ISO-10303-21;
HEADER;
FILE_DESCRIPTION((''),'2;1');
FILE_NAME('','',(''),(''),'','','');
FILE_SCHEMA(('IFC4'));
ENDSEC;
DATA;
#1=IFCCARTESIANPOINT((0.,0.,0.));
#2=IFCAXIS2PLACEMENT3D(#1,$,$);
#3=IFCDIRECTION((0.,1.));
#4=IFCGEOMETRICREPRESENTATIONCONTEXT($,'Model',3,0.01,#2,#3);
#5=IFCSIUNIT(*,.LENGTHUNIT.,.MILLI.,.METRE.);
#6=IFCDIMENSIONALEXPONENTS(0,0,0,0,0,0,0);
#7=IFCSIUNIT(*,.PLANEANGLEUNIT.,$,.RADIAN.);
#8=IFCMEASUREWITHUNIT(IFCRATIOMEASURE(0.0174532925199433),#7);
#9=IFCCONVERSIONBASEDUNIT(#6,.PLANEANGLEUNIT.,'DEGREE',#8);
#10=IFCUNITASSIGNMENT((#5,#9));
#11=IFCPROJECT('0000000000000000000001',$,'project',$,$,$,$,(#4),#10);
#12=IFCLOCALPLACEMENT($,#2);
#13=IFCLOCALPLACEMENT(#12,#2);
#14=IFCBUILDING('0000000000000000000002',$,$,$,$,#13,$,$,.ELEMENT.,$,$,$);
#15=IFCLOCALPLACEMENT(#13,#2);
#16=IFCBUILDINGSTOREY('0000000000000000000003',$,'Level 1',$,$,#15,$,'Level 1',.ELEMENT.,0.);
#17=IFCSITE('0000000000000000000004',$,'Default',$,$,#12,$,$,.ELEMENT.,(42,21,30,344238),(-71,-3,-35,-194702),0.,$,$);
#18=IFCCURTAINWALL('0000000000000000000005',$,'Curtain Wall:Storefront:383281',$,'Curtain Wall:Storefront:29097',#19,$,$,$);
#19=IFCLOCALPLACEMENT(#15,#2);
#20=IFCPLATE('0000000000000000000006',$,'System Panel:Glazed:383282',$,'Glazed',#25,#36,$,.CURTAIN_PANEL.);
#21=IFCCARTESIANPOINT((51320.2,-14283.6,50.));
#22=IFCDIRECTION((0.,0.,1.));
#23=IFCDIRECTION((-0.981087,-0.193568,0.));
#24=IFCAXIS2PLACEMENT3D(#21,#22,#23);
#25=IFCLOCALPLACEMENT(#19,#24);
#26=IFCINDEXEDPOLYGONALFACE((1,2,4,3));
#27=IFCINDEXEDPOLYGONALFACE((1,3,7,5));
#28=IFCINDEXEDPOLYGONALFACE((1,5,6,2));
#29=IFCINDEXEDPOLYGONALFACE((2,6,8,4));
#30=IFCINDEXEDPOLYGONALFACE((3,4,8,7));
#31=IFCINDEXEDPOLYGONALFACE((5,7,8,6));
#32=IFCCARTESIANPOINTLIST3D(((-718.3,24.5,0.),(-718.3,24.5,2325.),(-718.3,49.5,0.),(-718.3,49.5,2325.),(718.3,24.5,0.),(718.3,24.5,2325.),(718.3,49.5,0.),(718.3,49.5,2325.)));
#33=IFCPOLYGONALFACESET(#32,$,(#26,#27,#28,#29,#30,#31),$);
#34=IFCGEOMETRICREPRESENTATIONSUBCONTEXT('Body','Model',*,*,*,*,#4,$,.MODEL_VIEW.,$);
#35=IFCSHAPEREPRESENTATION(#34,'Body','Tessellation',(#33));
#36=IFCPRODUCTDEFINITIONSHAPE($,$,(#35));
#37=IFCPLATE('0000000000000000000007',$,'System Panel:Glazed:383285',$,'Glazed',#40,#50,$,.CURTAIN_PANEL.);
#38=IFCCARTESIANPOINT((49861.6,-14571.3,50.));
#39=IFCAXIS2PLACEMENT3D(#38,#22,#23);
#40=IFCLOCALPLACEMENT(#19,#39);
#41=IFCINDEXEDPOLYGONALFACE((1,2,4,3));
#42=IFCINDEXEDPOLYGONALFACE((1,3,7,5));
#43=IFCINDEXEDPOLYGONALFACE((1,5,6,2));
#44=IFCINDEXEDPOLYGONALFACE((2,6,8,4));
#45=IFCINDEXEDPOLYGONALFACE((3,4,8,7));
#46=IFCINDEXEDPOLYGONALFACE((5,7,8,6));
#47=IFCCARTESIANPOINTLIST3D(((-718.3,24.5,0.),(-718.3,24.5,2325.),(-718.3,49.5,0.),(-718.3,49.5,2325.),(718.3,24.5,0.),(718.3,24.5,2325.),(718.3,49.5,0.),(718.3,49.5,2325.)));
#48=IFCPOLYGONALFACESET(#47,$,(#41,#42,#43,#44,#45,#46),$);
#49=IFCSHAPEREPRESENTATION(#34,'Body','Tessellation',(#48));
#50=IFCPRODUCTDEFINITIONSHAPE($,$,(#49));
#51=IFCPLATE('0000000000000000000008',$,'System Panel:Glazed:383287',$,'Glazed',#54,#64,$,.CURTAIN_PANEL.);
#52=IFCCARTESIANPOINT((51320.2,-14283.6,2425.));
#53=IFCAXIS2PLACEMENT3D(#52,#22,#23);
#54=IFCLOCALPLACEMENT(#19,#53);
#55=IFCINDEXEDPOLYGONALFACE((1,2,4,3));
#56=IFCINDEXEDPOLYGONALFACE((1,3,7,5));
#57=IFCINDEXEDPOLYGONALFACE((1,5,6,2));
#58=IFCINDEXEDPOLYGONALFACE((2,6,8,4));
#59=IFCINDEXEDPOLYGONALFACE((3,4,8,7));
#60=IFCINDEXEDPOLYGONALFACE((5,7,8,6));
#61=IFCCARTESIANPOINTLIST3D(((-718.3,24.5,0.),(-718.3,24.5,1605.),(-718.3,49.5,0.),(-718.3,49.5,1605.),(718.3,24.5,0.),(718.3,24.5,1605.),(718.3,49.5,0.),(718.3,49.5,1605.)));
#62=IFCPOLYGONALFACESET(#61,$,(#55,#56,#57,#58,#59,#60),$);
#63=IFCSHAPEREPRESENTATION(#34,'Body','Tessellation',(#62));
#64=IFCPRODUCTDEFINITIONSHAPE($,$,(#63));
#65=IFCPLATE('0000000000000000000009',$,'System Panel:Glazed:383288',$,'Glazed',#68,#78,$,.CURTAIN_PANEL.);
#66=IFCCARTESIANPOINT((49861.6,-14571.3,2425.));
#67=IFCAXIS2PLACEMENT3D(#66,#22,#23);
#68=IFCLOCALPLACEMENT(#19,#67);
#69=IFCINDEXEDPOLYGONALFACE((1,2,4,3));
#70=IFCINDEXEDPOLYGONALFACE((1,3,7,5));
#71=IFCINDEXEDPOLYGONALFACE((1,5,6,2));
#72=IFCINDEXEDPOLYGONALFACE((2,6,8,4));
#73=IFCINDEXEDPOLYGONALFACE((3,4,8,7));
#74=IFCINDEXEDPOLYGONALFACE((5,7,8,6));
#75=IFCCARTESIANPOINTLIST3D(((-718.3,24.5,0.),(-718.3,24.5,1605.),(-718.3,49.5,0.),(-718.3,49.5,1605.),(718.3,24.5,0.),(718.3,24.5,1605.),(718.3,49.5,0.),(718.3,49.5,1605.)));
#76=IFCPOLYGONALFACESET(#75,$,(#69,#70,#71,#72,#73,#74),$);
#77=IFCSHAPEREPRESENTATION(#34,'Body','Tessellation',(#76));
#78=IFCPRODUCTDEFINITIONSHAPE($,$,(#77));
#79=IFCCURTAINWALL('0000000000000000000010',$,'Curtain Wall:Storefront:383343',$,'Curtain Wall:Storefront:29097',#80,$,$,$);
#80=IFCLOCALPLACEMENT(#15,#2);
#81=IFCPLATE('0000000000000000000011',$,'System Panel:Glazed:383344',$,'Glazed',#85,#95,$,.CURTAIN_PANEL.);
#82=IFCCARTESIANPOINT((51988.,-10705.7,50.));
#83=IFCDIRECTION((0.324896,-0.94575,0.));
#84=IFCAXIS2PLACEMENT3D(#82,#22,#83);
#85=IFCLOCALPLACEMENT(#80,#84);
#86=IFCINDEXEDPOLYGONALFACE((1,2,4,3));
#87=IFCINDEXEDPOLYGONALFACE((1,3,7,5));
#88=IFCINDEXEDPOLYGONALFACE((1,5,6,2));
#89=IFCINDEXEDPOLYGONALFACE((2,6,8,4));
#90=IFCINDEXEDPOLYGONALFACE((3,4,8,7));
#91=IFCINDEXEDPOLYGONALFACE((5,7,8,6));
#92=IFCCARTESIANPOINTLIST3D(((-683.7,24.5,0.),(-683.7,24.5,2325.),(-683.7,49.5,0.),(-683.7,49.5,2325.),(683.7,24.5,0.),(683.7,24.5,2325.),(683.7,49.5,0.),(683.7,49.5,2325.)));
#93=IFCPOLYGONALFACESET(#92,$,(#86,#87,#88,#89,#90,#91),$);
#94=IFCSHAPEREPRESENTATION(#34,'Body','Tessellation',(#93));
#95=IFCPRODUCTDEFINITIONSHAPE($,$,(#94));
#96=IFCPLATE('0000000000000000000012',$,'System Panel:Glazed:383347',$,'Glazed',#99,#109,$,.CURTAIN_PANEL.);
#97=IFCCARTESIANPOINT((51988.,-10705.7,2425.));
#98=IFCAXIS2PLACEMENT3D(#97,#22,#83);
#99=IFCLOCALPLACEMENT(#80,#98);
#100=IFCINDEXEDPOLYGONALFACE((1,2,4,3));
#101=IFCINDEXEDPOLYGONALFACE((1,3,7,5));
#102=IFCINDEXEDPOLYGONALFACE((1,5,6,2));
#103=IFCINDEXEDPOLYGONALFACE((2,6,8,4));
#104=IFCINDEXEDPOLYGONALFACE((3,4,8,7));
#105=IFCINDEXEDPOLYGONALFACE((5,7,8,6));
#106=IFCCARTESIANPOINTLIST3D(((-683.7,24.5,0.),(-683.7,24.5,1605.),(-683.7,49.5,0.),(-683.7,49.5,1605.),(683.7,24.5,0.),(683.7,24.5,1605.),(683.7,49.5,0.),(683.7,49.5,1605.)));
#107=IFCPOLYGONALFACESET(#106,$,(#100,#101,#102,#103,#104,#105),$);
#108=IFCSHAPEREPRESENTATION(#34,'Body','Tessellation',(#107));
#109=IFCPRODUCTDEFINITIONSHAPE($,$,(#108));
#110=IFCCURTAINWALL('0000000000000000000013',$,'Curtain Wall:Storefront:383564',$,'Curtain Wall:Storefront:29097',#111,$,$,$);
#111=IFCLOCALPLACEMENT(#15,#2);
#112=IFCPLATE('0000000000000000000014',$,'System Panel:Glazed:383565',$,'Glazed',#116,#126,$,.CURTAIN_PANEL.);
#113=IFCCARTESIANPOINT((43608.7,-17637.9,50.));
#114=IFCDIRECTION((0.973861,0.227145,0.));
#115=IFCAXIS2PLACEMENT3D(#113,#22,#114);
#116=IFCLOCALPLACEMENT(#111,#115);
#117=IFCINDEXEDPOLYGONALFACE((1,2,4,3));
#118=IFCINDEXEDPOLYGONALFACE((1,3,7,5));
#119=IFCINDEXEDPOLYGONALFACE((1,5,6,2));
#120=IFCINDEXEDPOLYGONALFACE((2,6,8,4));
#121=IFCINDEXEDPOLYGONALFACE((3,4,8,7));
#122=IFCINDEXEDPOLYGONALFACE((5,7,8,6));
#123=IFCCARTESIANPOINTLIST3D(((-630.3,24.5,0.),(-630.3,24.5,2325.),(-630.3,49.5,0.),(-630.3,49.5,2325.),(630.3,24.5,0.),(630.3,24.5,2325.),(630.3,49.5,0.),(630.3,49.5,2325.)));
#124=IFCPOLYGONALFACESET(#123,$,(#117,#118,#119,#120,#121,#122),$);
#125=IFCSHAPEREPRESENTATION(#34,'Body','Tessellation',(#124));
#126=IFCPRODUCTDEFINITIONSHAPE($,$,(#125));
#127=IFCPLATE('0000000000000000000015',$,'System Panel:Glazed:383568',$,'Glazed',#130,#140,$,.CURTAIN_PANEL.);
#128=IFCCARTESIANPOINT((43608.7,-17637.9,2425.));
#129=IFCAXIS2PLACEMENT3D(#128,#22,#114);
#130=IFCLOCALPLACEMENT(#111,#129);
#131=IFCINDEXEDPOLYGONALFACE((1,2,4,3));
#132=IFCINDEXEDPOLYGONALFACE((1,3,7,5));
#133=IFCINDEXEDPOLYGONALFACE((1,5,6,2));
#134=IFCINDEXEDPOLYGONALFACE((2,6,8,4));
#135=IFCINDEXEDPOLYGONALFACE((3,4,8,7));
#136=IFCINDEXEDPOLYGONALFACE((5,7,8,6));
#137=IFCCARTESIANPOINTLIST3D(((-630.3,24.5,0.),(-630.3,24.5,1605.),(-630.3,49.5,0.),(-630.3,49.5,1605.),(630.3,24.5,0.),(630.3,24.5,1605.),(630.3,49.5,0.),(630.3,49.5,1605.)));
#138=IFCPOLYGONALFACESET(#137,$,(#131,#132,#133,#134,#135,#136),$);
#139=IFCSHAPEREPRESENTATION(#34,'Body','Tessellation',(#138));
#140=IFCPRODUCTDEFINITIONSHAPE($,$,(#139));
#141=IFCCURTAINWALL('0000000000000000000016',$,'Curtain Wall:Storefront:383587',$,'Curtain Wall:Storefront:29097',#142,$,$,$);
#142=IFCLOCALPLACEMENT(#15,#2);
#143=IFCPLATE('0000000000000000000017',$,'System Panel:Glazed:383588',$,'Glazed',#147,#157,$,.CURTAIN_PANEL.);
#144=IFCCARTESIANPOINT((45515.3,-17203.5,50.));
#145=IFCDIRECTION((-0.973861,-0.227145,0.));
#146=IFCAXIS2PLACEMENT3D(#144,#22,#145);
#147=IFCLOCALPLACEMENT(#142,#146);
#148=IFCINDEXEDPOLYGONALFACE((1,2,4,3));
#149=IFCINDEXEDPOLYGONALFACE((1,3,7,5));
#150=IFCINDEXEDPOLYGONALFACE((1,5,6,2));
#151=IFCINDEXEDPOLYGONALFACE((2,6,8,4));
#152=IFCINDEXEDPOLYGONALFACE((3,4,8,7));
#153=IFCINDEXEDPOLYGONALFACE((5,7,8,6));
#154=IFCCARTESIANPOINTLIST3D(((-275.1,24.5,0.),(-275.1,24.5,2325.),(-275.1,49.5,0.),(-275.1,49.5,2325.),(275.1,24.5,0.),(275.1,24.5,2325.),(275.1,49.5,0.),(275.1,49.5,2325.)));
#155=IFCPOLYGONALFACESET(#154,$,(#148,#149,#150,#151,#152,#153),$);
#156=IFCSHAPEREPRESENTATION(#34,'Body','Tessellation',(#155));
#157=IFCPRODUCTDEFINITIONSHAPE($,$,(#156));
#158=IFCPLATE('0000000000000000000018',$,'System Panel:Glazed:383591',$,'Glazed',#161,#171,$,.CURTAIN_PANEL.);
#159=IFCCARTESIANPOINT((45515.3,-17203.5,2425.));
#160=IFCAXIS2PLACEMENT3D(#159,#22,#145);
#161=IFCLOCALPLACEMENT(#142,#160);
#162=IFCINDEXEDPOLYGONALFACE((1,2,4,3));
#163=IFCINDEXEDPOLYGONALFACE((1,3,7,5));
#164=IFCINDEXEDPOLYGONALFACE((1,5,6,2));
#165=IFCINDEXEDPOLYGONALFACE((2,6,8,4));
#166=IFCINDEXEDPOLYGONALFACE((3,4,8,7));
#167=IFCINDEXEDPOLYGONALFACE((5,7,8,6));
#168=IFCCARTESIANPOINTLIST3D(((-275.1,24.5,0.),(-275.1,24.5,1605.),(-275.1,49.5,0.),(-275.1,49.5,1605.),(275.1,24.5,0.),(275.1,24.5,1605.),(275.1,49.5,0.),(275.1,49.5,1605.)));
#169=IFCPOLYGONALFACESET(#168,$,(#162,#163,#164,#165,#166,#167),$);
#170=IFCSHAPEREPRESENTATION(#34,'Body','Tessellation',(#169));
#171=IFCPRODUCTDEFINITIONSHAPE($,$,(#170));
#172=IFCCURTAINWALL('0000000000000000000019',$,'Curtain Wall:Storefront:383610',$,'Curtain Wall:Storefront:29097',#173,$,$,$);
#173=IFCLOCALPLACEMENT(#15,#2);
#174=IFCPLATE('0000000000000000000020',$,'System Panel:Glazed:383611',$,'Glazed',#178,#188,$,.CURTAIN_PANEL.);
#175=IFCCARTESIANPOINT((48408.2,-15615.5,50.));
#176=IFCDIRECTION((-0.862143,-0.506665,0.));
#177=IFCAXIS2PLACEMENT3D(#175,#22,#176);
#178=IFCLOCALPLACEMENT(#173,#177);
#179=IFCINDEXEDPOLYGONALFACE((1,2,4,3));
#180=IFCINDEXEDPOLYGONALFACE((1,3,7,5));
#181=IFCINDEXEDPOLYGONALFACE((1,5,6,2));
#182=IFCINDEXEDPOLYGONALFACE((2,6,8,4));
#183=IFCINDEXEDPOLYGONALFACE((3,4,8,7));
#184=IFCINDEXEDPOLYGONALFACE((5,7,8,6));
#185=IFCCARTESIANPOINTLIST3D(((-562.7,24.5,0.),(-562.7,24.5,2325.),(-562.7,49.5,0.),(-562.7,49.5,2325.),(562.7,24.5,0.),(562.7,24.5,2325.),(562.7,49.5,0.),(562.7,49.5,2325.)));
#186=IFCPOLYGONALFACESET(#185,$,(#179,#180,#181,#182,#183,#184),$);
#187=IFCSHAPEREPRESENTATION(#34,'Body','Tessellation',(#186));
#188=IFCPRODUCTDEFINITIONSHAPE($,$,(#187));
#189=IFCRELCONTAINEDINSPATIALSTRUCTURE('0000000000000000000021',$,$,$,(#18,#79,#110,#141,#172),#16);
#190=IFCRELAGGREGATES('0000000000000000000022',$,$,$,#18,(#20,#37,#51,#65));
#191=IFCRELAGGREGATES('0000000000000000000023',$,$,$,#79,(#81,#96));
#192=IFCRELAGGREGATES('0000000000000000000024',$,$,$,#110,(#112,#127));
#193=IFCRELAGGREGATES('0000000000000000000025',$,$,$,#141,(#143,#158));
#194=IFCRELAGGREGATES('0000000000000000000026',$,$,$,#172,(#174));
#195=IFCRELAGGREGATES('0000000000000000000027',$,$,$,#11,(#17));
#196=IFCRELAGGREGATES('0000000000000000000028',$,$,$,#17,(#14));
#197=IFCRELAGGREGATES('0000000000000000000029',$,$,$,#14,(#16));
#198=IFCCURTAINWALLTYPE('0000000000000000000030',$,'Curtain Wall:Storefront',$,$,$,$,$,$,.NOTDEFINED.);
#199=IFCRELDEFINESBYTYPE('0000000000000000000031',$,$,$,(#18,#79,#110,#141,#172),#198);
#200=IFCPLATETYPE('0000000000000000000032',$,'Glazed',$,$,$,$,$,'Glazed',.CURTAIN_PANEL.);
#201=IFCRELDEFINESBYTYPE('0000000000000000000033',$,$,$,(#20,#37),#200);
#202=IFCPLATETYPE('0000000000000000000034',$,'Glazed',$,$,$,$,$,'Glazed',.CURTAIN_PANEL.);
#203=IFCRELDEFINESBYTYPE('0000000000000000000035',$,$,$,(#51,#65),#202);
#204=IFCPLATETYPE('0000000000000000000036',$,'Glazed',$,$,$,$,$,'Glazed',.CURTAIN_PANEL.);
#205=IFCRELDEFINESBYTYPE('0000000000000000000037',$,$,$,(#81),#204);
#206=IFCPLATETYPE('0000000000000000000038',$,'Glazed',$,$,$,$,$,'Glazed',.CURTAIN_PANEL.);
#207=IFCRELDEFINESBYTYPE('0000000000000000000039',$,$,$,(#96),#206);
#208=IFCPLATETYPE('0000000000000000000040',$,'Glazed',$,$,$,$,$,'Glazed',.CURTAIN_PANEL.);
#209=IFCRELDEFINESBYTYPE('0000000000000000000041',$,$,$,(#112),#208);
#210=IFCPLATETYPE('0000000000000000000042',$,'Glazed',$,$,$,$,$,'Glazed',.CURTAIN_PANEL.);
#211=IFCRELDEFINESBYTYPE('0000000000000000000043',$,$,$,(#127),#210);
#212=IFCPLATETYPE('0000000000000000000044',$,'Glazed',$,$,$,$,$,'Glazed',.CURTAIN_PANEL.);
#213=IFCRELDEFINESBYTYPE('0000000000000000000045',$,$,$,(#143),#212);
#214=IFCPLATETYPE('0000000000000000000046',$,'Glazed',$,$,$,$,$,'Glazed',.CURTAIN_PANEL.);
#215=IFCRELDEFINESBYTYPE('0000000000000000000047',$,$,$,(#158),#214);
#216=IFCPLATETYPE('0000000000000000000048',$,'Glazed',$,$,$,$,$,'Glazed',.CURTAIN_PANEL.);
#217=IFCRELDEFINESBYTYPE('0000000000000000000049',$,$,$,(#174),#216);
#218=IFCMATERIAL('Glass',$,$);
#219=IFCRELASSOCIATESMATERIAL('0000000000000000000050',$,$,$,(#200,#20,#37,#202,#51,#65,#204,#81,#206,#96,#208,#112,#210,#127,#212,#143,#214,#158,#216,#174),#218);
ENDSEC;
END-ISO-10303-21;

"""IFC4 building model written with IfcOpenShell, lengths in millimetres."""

from ifc_helpers import new_model, entity, si_unit, converted_unit, direction, frame, frame_2d, origin, place, context, subcontext, project, spatial, rectangle, extrude, source, transform, mapped, material, type_object, type_shapes, element, aggregate, save


model = new_model("IFC4")

# Units and contexts
model_context = context("Model", 3, precision=0.01, world=origin(), true_north=direction((0.0, 1.0)))
body_context = subcontext(model_context, "Body", "Model", "MODEL_VIEW")
ifc_project = project(units=[si_unit("LENGTHUNIT", "METRE", prefix="MILLI"), converted_unit("PLANEANGLEUNIT", "DEGREE", entity("IfcRatioMeasure", 0.0174532925199433), si_unit("PLANEANGLEUNIT", "RADIAN"), dimensions=[0, 0, 0, 0, 0, 0, 0])], contexts=[model_context])

# Site, building, storey
site_placement = place(None, origin())
site = spatial("IfcSite", under=ifc_project, at=site_placement, Name="Default", CompositionType="ELEMENT", RefLatitude=(42, 21, 30, 344238), RefLongitude=(-71, -3, -35, -194702), RefElevation=0.0)
building_placement = place(site_placement, origin())
building = spatial("IfcBuilding", under=site, at=building_placement, CompositionType="ELEMENT")
storey_placement = place(building_placement, origin())
storey = spatial("IfcBuildingStorey", under=building, at=storey_placement, Name="Level 1", LongName="Level 1", CompositionType="ELEMENT", Elevation=0.0)

# Curtain walls, plates
curtain_wall_type = type_object("IfcCurtainWallType", Name="Curtain Wall:Storefront", PredefinedType="NOTDEFINED")
curtain_wall_1_placement = place(storey_placement, origin())
curtain_wall_1 = element("IfcCurtainWall", 1, at=curtain_wall_1_placement, inside=storey, type_object=curtain_wall_type, Name="Curtain Wall:Storefront:383281", ObjectType="Curtain Wall:Storefront:29097")
ifc_material_1 = material(Name="Glass")
plate_type_1 = type_object("IfcPlateType", Name="Glazed", ElementType="Glazed", PredefinedType="CURTAIN_PANEL", material=ifc_material_1)
shared_shape_1 = source(origin(), body_context, "Body", "SweptSolid", [
    extrude(rectangle(XDim=25.0, YDim=1436.7, at=frame_2d((0.0, 0.0), x_axis=(1.0, 0.0))), frame((0.0, 37.0, 0.0), z_axis=(0.0, 0.0, 1.0), x_axis=(0.0, 1.0, 0.0)), (0.0, 0.0, 1.0), 2325.0),
])
type_shapes(plate_type_1, [shared_shape_1])
plate_1_placement = place(curtain_wall_1_placement, frame((51320.2, -14283.6, 50.0), z_axis=(0.0, 0.0, 1.0), x_axis=(-0.981087, -0.193568, 0.0)))
plate_1 = element("IfcPlate", 2, at=plate_1_placement, type_object=plate_type_1, material=ifc_material_1, Name="System Panel:Glazed:383282", ObjectType="Glazed", PredefinedType="CURTAIN_PANEL", context=body_context, shape_type="MappedRepresentation", body=[
    mapped(shared_shape_1, transform((0.0, 0.0, 0.0), scale=1.0)),
])
plate_2_placement = place(curtain_wall_1_placement, frame((49861.6, -14571.3, 50.0), z_axis=(0.0, 0.0, 1.0), x_axis=(-0.981087, -0.193568, 0.0)))
plate_2 = element("IfcPlate", 3, at=plate_2_placement, type_object=plate_type_1, material=ifc_material_1, Name="System Panel:Glazed:383285", ObjectType="Glazed", PredefinedType="CURTAIN_PANEL", context=body_context, shape_type="MappedRepresentation", body=[
    mapped(shared_shape_1, transform((0.0, 0.0, 0.0), scale=1.0)),
])
plate_type_2 = type_object("IfcPlateType", Name="Glazed", ElementType="Glazed", PredefinedType="CURTAIN_PANEL", material=ifc_material_1)
shared_shape_2 = source(origin(), body_context, "Body", "SweptSolid", [
    extrude(rectangle(XDim=25.0, YDim=1436.7, at=frame_2d((0.0, 0.0), x_axis=(1.0, 0.0))), frame((0.0, 37.0, 0.0), z_axis=(0.0, 0.0, 1.0), x_axis=(0.0, 1.0, 0.0)), (0.0, 0.0, 1.0), 1605.0),
])
type_shapes(plate_type_2, [shared_shape_2])
plate_3_placement = place(curtain_wall_1_placement, frame((51320.2, -14283.6, 2425.0), z_axis=(0.0, 0.0, 1.0), x_axis=(-0.981087, -0.193568, 0.0)))
plate_3 = element("IfcPlate", 4, at=plate_3_placement, type_object=plate_type_2, material=ifc_material_1, Name="System Panel:Glazed:383287", ObjectType="Glazed", PredefinedType="CURTAIN_PANEL", context=body_context, shape_type="MappedRepresentation", body=[
    mapped(shared_shape_2, transform((0.0, 0.0, 0.0), scale=1.0)),
])
plate_4_placement = place(curtain_wall_1_placement, frame((49861.6, -14571.3, 2425.0), z_axis=(0.0, 0.0, 1.0), x_axis=(-0.981087, -0.193568, 0.0)))
plate_4 = element("IfcPlate", 5, at=plate_4_placement, type_object=plate_type_2, material=ifc_material_1, Name="System Panel:Glazed:383288", ObjectType="Glazed", PredefinedType="CURTAIN_PANEL", context=body_context, shape_type="MappedRepresentation", body=[
    mapped(shared_shape_2, transform((0.0, 0.0, 0.0), scale=1.0)),
])
aggregate(curtain_wall_1, [plate_1, plate_2, plate_3, plate_4])
curtain_wall_2_placement = place(storey_placement, origin())
curtain_wall_2 = element("IfcCurtainWall", 6, at=curtain_wall_2_placement, inside=storey, type_object=curtain_wall_type, Name="Curtain Wall:Storefront:383343", ObjectType="Curtain Wall:Storefront:29097")
plate_type_3 = type_object("IfcPlateType", Name="Glazed", ElementType="Glazed", PredefinedType="CURTAIN_PANEL", material=ifc_material_1)
shared_shape_3 = source(origin(), body_context, "Body", "SweptSolid", [
    extrude(rectangle(XDim=25.0, YDim=1367.5, at=frame_2d((0.0, 0.0), x_axis=(1.0, 0.0))), frame((0.0, 37.0, 0.0), z_axis=(0.0, 0.0, 1.0), x_axis=(0.0, 1.0, 0.0)), (0.0, 0.0, 1.0), 2325.0),
])
type_shapes(plate_type_3, [shared_shape_3])
plate_5_placement = place(curtain_wall_2_placement, frame((51988.0, -10705.7, 50.0), z_axis=(0.0, 0.0, 1.0), x_axis=(0.324896, -0.94575, 0.0)))
plate_5 = element("IfcPlate", 7, at=plate_5_placement, type_object=plate_type_3, material=ifc_material_1, Name="System Panel:Glazed:383344", ObjectType="Glazed", PredefinedType="CURTAIN_PANEL", context=body_context, shape_type="MappedRepresentation", body=[
    mapped(shared_shape_3, transform((0.0, 0.0, 0.0), scale=1.0)),
])
plate_type_4 = type_object("IfcPlateType", Name="Glazed", ElementType="Glazed", PredefinedType="CURTAIN_PANEL", material=ifc_material_1)
shared_shape_4 = source(origin(), body_context, "Body", "SweptSolid", [
    extrude(rectangle(XDim=25.0, YDim=1367.5, at=frame_2d((0.0, 0.0), x_axis=(1.0, 0.0))), frame((0.0, 37.0, 0.0), z_axis=(0.0, 0.0, 1.0), x_axis=(0.0, 1.0, 0.0)), (0.0, 0.0, 1.0), 1605.0),
])
type_shapes(plate_type_4, [shared_shape_4])
plate_6_placement = place(curtain_wall_2_placement, frame((51988.0, -10705.7, 2425.0), z_axis=(0.0, 0.0, 1.0), x_axis=(0.324896, -0.94575, 0.0)))
plate_6 = element("IfcPlate", 8, at=plate_6_placement, type_object=plate_type_4, material=ifc_material_1, Name="System Panel:Glazed:383347", ObjectType="Glazed", PredefinedType="CURTAIN_PANEL", context=body_context, shape_type="MappedRepresentation", body=[
    mapped(shared_shape_4, transform((0.0, 0.0, 0.0), scale=1.0)),
])
aggregate(curtain_wall_2, [plate_5, plate_6])
curtain_wall_3_placement = place(storey_placement, origin())
curtain_wall_3 = element("IfcCurtainWall", 9, at=curtain_wall_3_placement, inside=storey, type_object=curtain_wall_type, Name="Curtain Wall:Storefront:383564", ObjectType="Curtain Wall:Storefront:29097")
plate_type_5 = type_object("IfcPlateType", Name="Glazed", ElementType="Glazed", PredefinedType="CURTAIN_PANEL", material=ifc_material_1)
shared_shape_5 = source(origin(), body_context, "Body", "SweptSolid", [
    extrude(rectangle(XDim=25.0, YDim=1260.7, at=frame_2d((0.0, 0.0), x_axis=(1.0, 0.0))), frame((0.0, 37.0, 0.0), z_axis=(0.0, 0.0, 1.0), x_axis=(0.0, 1.0, 0.0)), (0.0, 0.0, 1.0), 2325.0),
])
type_shapes(plate_type_5, [shared_shape_5])
plate_7_placement = place(curtain_wall_3_placement, frame((43608.7, -17637.9, 50.0), z_axis=(0.0, 0.0, 1.0), x_axis=(0.973861, 0.227145, 0.0)))
plate_7 = element("IfcPlate", 10, at=plate_7_placement, type_object=plate_type_5, material=ifc_material_1, Name="System Panel:Glazed:383565", ObjectType="Glazed", PredefinedType="CURTAIN_PANEL", context=body_context, shape_type="MappedRepresentation", body=[
    mapped(shared_shape_5, transform((0.0, 0.0, 0.0), scale=1.0)),
])
plate_type_6 = type_object("IfcPlateType", Name="Glazed", ElementType="Glazed", PredefinedType="CURTAIN_PANEL", material=ifc_material_1)
shared_shape_6 = source(origin(), body_context, "Body", "SweptSolid", [
    extrude(rectangle(XDim=25.0, YDim=1260.7, at=frame_2d((0.0, 0.0), x_axis=(1.0, 0.0))), frame((0.0, 37.0, 0.0), z_axis=(0.0, 0.0, 1.0), x_axis=(0.0, 1.0, 0.0)), (0.0, 0.0, 1.0), 1605.0),
])
type_shapes(plate_type_6, [shared_shape_6])
plate_8_placement = place(curtain_wall_3_placement, frame((43608.7, -17637.9, 2425.0), z_axis=(0.0, 0.0, 1.0), x_axis=(0.973861, 0.227145, 0.0)))
plate_8 = element("IfcPlate", 11, at=plate_8_placement, type_object=plate_type_6, material=ifc_material_1, Name="System Panel:Glazed:383568", ObjectType="Glazed", PredefinedType="CURTAIN_PANEL", context=body_context, shape_type="MappedRepresentation", body=[
    mapped(shared_shape_6, transform((0.0, 0.0, 0.0), scale=1.0)),
])
aggregate(curtain_wall_3, [plate_7, plate_8])
curtain_wall_4_placement = place(storey_placement, origin())
curtain_wall_4 = element("IfcCurtainWall", 12, at=curtain_wall_4_placement, inside=storey, type_object=curtain_wall_type, Name="Curtain Wall:Storefront:383587", ObjectType="Curtain Wall:Storefront:29097")
plate_type_7 = type_object("IfcPlateType", Name="Glazed", ElementType="Glazed", PredefinedType="CURTAIN_PANEL", material=ifc_material_1)
shared_shape_7 = source(origin(), body_context, "Body", "SweptSolid", [
    extrude(rectangle(XDim=25.0, YDim=550.1, at=frame_2d((0.0, 0.0), x_axis=(1.0, 0.0))), frame((0.0, 37.0, 0.0), z_axis=(0.0, 0.0, 1.0), x_axis=(0.0, 1.0, 0.0)), (0.0, 0.0, 1.0), 2325.0),
])
type_shapes(plate_type_7, [shared_shape_7])
plate_9_placement = place(curtain_wall_4_placement, frame((45515.3, -17203.5, 50.0), z_axis=(0.0, 0.0, 1.0), x_axis=(-0.973861, -0.227145, 0.0)))
plate_9 = element("IfcPlate", 13, at=plate_9_placement, type_object=plate_type_7, material=ifc_material_1, Name="System Panel:Glazed:383588", ObjectType="Glazed", PredefinedType="CURTAIN_PANEL", context=body_context, shape_type="MappedRepresentation", body=[
    mapped(shared_shape_7, transform((0.0, 0.0, 0.0), scale=1.0)),
])
plate_type_8 = type_object("IfcPlateType", Name="Glazed", ElementType="Glazed", PredefinedType="CURTAIN_PANEL", material=ifc_material_1)
shared_shape_8 = source(origin(), body_context, "Body", "SweptSolid", [
    extrude(rectangle(XDim=25.0, YDim=550.1, at=frame_2d((0.0, 0.0), x_axis=(1.0, 0.0))), frame((0.0, 37.0, 0.0), z_axis=(0.0, 0.0, 1.0), x_axis=(0.0, 1.0, 0.0)), (0.0, 0.0, 1.0), 1605.0),
])
type_shapes(plate_type_8, [shared_shape_8])
plate_10_placement = place(curtain_wall_4_placement, frame((45515.3, -17203.5, 2425.0), z_axis=(0.0, 0.0, 1.0), x_axis=(-0.973861, -0.227145, 0.0)))
plate_10 = element("IfcPlate", 14, at=plate_10_placement, type_object=plate_type_8, material=ifc_material_1, Name="System Panel:Glazed:383591", ObjectType="Glazed", PredefinedType="CURTAIN_PANEL", context=body_context, shape_type="MappedRepresentation", body=[
    mapped(shared_shape_8, transform((0.0, 0.0, 0.0), scale=1.0)),
])
aggregate(curtain_wall_4, [plate_9, plate_10])
curtain_wall_5_placement = place(storey_placement, origin())
curtain_wall_5 = element("IfcCurtainWall", 15, at=curtain_wall_5_placement, inside=storey, type_object=curtain_wall_type, Name="Curtain Wall:Storefront:383610", ObjectType="Curtain Wall:Storefront:29097")
plate_type_9 = type_object("IfcPlateType", Name="Glazed", ElementType="Glazed", PredefinedType="CURTAIN_PANEL", material=ifc_material_1)
shared_shape_9 = source(origin(), body_context, "Body", "SweptSolid", [
    extrude(rectangle(XDim=25.0, YDim=1125.3, at=frame_2d((0.0, 0.0), x_axis=(1.0, 0.0))), frame((0.0, 37.0, 0.0), z_axis=(0.0, 0.0, 1.0), x_axis=(0.0, 1.0, 0.0)), (0.0, 0.0, 1.0), 2325.0),
])
type_shapes(plate_type_9, [shared_shape_9])
plate_11_placement = place(curtain_wall_5_placement, frame((48408.2, -15615.5, 50.0), z_axis=(0.0, 0.0, 1.0), x_axis=(-0.862143, -0.506665, 0.0)))
plate_11 = element("IfcPlate", 16, at=plate_11_placement, type_object=plate_type_9, material=ifc_material_1, Name="System Panel:Glazed:383611", ObjectType="Glazed", PredefinedType="CURTAIN_PANEL", context=body_context, shape_type="MappedRepresentation", body=[
    mapped(shared_shape_9, transform((0.0, 0.0, 0.0), scale=1.0)),
])
aggregate(curtain_wall_5, [plate_11])

save(model, "model.ifc")
